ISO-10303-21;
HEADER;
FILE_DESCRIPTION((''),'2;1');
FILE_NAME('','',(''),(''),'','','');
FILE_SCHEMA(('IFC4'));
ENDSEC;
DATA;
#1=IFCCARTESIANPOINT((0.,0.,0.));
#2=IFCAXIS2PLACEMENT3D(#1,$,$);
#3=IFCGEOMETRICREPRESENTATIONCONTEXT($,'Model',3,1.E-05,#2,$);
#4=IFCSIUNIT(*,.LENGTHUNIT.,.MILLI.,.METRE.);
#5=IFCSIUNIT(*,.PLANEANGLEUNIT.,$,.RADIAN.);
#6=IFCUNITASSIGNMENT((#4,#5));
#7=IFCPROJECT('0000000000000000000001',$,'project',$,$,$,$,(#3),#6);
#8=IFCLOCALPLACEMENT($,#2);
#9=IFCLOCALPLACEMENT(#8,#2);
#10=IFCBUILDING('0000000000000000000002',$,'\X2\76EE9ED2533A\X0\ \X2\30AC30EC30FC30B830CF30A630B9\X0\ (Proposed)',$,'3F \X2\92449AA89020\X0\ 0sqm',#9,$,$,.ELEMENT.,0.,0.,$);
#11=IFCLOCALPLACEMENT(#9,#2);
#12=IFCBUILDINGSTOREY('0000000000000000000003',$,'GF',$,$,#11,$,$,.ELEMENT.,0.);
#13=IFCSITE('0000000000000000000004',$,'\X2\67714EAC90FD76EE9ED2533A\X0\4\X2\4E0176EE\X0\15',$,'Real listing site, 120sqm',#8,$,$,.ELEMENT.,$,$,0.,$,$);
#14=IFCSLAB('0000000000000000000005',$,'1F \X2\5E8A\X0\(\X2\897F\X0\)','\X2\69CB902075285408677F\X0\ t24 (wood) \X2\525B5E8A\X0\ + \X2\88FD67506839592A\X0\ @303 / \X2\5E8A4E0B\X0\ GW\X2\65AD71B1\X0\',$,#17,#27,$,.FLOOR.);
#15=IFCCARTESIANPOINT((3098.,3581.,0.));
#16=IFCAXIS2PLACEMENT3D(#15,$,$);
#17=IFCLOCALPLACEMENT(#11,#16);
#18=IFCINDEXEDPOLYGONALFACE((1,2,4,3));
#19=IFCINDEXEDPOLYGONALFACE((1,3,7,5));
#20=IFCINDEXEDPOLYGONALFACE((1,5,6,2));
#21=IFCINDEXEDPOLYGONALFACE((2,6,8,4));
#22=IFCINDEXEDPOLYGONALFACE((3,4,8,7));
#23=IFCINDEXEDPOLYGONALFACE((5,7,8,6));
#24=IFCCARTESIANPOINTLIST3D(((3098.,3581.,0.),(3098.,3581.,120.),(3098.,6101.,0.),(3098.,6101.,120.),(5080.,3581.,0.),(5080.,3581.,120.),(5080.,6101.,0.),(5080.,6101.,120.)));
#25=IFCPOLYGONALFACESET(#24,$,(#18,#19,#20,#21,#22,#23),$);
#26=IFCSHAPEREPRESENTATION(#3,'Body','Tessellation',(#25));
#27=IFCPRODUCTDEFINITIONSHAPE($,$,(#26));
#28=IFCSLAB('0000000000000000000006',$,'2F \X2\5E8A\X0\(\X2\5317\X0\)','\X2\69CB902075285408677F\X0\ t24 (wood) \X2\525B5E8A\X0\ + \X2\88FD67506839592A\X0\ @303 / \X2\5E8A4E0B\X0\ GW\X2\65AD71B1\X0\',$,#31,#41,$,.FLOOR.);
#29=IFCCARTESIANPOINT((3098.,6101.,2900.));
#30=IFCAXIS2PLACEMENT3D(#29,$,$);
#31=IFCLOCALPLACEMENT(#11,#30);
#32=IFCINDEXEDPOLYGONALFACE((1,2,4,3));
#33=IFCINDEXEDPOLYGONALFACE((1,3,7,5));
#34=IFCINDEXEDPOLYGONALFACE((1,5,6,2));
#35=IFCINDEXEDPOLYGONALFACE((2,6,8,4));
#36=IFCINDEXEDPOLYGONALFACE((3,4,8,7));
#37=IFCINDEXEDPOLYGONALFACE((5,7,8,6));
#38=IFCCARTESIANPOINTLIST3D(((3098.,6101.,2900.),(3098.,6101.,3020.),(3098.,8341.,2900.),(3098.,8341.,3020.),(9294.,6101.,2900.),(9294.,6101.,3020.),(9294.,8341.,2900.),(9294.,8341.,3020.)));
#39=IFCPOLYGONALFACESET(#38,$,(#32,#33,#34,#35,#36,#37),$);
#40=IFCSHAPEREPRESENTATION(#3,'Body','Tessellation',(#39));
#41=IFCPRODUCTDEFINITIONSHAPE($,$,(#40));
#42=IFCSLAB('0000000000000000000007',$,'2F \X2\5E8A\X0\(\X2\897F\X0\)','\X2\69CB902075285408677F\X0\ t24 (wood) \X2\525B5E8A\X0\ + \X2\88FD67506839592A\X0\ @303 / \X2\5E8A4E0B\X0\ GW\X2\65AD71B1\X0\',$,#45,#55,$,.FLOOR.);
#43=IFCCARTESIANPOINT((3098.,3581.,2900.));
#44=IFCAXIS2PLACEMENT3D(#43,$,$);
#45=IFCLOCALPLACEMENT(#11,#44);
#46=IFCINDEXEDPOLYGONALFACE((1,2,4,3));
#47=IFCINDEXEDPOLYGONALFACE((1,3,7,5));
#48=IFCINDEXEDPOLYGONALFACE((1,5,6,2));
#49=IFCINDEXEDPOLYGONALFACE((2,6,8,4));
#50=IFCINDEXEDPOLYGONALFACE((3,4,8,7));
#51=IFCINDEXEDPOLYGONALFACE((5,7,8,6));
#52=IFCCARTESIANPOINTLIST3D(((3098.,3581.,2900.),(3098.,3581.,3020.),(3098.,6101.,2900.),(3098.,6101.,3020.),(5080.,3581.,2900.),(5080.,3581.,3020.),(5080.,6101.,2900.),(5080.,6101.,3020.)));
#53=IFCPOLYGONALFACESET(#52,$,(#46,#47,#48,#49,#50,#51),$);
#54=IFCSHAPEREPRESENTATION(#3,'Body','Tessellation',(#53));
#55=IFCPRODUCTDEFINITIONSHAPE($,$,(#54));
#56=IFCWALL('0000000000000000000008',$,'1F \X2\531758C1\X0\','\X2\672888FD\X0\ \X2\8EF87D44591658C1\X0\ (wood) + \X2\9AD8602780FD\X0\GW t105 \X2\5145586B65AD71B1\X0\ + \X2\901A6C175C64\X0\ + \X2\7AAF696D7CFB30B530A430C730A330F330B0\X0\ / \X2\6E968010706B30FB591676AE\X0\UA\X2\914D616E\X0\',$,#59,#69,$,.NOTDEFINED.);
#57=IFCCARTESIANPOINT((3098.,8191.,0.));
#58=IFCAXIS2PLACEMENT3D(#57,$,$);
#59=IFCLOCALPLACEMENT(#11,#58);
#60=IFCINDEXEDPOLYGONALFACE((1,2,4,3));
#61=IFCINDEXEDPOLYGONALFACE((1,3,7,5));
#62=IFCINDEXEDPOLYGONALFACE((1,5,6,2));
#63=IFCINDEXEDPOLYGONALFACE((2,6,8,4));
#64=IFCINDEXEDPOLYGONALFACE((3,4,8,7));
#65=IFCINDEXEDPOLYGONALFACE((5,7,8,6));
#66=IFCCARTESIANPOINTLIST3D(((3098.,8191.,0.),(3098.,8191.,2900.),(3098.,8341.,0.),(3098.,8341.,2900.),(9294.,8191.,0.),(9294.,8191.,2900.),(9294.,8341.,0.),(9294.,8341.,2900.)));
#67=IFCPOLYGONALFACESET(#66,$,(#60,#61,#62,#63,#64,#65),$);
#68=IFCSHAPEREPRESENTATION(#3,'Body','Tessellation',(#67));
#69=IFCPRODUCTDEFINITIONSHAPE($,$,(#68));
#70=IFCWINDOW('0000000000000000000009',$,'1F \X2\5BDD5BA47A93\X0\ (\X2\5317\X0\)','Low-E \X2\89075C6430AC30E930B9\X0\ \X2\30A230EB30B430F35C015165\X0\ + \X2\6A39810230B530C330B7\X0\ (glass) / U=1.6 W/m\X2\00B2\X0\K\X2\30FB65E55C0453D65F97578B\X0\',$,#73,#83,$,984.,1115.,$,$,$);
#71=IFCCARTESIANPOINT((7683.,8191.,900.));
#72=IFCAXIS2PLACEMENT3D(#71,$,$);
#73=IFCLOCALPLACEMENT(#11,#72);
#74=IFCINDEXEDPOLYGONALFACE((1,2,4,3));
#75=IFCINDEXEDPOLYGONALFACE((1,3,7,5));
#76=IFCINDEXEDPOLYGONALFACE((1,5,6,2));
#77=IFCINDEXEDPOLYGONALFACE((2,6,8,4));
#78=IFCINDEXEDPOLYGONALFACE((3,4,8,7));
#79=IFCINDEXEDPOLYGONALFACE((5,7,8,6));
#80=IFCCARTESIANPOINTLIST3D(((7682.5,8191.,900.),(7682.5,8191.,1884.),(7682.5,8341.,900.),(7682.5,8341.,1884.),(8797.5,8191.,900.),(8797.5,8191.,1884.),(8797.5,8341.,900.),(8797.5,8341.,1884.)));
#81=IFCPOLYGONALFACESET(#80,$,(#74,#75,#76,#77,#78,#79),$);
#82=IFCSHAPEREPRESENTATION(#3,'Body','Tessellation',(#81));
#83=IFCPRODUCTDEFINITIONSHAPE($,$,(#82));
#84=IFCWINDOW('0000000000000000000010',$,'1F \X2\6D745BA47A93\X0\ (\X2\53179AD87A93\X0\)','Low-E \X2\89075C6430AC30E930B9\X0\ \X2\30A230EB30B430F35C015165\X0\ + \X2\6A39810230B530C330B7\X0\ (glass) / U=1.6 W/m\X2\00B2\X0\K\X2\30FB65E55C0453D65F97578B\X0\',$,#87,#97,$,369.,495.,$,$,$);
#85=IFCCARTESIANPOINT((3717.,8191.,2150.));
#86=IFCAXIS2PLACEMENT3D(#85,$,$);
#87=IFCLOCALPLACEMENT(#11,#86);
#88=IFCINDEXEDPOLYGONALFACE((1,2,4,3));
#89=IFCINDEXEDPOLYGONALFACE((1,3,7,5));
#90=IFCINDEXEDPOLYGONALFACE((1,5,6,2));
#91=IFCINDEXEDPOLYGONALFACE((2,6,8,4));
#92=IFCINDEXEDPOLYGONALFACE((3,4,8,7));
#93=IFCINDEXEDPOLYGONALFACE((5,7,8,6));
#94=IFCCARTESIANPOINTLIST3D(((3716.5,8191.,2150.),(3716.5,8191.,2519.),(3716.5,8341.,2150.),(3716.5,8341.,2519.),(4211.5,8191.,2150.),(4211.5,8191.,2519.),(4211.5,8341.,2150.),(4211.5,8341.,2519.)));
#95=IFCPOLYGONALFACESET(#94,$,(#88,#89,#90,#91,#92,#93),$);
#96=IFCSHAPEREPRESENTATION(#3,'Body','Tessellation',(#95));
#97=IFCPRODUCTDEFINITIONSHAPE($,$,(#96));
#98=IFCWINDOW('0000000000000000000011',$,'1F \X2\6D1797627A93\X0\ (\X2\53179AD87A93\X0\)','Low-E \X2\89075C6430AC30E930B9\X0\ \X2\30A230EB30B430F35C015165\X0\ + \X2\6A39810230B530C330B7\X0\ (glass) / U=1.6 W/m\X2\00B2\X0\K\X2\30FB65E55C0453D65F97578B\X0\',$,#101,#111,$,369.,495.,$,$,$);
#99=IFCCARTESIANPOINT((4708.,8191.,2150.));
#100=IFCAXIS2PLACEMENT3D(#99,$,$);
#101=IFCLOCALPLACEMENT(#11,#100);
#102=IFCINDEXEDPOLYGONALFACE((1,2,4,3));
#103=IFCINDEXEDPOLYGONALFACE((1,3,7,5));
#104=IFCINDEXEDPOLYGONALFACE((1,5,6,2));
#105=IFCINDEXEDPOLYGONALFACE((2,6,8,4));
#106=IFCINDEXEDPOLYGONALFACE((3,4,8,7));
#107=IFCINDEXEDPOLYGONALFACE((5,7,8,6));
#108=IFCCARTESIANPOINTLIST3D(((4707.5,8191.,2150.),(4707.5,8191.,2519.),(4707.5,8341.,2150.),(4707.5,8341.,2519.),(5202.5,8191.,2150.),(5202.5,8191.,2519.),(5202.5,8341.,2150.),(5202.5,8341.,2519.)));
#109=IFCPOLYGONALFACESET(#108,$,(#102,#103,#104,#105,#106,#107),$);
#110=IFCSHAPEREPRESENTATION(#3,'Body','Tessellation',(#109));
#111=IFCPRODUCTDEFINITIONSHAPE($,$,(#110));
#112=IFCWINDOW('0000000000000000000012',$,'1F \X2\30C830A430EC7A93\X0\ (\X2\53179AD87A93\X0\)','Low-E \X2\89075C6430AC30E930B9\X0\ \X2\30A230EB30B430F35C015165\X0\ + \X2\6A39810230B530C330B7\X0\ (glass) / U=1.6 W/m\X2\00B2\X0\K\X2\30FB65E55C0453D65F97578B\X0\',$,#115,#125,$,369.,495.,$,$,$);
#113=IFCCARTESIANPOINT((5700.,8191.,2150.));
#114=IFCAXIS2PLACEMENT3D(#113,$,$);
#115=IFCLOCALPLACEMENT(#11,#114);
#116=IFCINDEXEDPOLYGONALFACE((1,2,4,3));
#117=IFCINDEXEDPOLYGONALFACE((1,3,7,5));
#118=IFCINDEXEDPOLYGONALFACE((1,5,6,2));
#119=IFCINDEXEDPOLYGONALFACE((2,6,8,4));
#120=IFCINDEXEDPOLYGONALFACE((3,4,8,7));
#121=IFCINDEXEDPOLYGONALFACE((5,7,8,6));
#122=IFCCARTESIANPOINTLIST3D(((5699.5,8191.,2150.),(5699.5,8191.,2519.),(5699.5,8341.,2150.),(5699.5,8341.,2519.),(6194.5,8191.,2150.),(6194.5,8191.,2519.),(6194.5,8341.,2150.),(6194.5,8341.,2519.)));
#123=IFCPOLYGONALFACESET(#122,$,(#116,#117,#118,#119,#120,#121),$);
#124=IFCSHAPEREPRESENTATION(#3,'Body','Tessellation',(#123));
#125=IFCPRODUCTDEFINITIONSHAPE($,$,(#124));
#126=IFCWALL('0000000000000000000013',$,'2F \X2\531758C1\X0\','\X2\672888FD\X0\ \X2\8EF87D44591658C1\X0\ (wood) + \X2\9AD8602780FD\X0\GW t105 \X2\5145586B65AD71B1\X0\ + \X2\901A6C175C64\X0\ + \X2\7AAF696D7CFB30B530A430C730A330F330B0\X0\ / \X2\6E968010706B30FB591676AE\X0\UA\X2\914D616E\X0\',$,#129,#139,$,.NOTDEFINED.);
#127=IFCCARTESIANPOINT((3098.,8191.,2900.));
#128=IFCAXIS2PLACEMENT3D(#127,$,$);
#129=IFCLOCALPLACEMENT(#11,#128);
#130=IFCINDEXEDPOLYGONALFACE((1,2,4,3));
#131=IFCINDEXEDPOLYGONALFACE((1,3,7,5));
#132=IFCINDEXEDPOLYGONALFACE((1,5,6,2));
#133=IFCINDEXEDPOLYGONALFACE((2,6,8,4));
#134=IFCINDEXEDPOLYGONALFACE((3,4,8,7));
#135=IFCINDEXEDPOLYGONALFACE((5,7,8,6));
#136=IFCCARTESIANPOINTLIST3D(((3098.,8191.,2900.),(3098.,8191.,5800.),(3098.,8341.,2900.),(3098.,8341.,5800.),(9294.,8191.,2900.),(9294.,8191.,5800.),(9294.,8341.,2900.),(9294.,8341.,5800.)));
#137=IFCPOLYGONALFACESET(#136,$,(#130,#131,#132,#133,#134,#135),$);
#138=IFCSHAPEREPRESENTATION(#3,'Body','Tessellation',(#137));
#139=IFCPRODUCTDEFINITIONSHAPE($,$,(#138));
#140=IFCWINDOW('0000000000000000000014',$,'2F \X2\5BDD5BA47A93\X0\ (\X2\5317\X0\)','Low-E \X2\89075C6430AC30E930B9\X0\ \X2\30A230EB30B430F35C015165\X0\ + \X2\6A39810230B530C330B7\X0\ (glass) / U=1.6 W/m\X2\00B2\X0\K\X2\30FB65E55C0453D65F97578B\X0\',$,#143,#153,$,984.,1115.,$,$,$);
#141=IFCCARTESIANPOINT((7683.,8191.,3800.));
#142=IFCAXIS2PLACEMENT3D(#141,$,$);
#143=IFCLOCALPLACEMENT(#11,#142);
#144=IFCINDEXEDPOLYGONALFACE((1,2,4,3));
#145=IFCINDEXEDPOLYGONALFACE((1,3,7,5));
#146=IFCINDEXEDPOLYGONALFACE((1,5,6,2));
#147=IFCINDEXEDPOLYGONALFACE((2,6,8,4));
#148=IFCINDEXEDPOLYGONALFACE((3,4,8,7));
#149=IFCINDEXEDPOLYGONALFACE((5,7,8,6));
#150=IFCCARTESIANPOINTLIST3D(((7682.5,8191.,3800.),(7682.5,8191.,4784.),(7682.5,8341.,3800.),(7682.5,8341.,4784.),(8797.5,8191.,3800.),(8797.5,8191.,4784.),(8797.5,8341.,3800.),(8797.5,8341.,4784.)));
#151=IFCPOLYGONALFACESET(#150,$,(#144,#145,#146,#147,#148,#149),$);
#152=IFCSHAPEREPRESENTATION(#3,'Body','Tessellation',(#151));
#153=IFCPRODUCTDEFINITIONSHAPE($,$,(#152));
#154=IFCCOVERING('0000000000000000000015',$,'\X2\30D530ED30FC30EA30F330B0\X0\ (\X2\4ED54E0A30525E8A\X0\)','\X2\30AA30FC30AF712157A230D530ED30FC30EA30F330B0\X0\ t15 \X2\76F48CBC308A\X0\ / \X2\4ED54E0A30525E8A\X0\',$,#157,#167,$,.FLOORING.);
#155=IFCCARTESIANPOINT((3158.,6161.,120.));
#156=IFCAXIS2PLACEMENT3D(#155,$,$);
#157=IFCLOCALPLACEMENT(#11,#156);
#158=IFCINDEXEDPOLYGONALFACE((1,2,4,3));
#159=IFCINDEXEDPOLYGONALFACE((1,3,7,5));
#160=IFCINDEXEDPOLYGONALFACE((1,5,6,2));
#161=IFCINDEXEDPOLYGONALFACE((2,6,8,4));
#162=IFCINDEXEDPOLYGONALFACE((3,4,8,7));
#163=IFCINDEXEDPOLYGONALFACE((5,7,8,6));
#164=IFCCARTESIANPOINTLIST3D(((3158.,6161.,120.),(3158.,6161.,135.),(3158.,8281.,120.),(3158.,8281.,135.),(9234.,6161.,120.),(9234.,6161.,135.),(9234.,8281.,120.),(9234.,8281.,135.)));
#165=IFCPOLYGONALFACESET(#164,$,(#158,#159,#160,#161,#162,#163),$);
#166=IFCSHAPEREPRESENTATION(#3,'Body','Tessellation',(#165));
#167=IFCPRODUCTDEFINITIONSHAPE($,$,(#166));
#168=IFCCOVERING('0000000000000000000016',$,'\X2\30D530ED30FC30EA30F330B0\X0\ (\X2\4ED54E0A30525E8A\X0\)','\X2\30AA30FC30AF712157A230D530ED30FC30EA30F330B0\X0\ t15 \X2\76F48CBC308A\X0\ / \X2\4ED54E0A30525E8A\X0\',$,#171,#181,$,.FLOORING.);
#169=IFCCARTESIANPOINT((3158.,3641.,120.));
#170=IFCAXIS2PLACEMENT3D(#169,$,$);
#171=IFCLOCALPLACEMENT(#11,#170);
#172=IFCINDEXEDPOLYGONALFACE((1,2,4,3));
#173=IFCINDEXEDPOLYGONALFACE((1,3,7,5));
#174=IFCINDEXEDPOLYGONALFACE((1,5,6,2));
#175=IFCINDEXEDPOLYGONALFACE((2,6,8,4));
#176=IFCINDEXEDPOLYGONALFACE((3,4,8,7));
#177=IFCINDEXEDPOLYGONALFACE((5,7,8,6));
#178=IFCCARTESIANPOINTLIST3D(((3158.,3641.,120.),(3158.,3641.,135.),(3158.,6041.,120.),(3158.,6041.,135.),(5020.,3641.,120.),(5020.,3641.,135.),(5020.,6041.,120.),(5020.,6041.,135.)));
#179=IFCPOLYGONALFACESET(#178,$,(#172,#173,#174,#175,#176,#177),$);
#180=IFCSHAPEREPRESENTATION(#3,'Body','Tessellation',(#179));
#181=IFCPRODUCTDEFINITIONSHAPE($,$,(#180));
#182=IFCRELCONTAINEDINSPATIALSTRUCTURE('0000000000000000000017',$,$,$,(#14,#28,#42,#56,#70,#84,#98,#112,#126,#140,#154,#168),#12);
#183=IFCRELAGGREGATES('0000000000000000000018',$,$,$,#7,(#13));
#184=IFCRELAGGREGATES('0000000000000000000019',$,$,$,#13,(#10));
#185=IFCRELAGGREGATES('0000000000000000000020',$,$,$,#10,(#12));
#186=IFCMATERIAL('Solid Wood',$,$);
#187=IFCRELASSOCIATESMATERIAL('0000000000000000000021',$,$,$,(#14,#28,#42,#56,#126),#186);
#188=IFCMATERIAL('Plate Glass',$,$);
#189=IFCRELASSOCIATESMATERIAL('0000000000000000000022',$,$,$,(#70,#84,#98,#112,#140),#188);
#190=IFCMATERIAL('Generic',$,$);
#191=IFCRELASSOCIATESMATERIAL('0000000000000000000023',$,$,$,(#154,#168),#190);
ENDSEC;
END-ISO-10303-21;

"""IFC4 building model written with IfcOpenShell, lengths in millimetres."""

from ifc_helpers import new_model, si_unit, frame, frame_2d, origin, place, context, project, spatial, rectangle, extrude, material, element, fill, save


model = new_model("IFC4")

# Units and contexts
model_context = context("Model", 3, precision=1e-05, world=origin())
ifc_project = project(units=[si_unit("LENGTHUNIT", "METRE", prefix="MILLI"), si_unit("PLANEANGLEUNIT", "RADIAN")], contexts=[model_context])

# Site, building, storey
site_placement = place(None, origin())
site = spatial("IfcSite", under=ifc_project, at=site_placement, Name="東京都目黒区4丁目15", ObjectType="Real listing site, 120sqm", CompositionType="ELEMENT", RefElevation=0.0)
building_placement = place(site_placement, origin())
building = spatial("IfcBuilding", under=site, at=building_placement, Name="目黒区 ガレージハウス (Proposed)", ObjectType="3F 鉄骨造 0sqm", CompositionType="ELEMENT", ElevationOfRefHeight=0.0, ElevationOfTerrain=0.0)
storey_placement = place(building_placement, origin())
storey = spatial("IfcBuildingStorey", under=building, at=storey_placement, Name="GF", CompositionType="ELEMENT", Elevation=0.0)

# Slabs
ifc_material_1 = material(Name="Solid Wood")
slab_1_placement = place(storey_placement, frame((3098.0, 3581.0, 0.0)))
element("IfcSlab", 1, at=slab_1_placement, inside=storey, material=ifc_material_1, Name="1F 床(西)", Description="構造用合板 t24 (wood) 剛床 + 製材根太 @303 / 床下 GW断熱", PredefinedType="FLOOR", context=model_context, shape_type="SweptSolid", body=[
    extrude(rectangle(XDim=1982.0, YDim=2520.0, at=frame_2d((991.0, 1260.0))), frame((3098.0, 3581.0, 0.0)), (0.0, 0.0, 1.0), 120.0),
])
slab_2_placement = place(storey_placement, frame((3098.0, 6101.0, 2900.0)))
element("IfcSlab", 2, at=slab_2_placement, inside=storey, material=ifc_material_1, Name="2F 床(北)", Description="構造用合板 t24 (wood) 剛床 + 製材根太 @303 / 床下 GW断熱", PredefinedType="FLOOR", context=model_context, shape_type="SweptSolid", body=[
    extrude(rectangle(XDim=6196.0, YDim=2240.0, at=frame_2d((3098.0, 1120.0))), frame((3098.0, 6101.0, 2900.0)), (0.0, 0.0, 1.0), 120.0),
])
slab_3_placement = place(storey_placement, frame((3098.0, 3581.0, 2900.0)))
element("IfcSlab", 3, at=slab_3_placement, inside=storey, material=ifc_material_1, Name="2F 床(西)", Description="構造用合板 t24 (wood) 剛床 + 製材根太 @303 / 床下 GW断熱", PredefinedType="FLOOR", context=model_context, shape_type="SweptSolid", body=[
    extrude(rectangle(XDim=1982.0, YDim=2520.0, at=frame_2d((991.0, 1260.0))), frame((3098.0, 3581.0, 2900.0)), (0.0, 0.0, 1.0), 120.0),
])

# Wall, openings, windows
wall_1_placement = place(storey_placement, frame((3098.0, 8191.0, 0.0)))
wall_1 = element("IfcWall", 4, at=wall_1_placement, inside=storey, material=ifc_material_1, Name="1F 北壁", Description="木製 軸組外壁 (wood) + 高性能GW t105 充填断熱 + 通気層 + 窯業系サイディング / 準耐火・外皮UA配慮", PredefinedType="NOTDEFINED", context=model_context, shape_type="SweptSolid", body=[
    extrude(rectangle(XDim=6196.0, YDim=150.0, at=frame_2d((3098.0, 75.0))), frame((3098.0, 8191.0, 0.0)), (0.0, 0.0, 1.0), 2900.0),
])
opening_1_placement = place(storey_placement, frame((7683.0, 8191.0, 900.0)))
opening_1 = element("IfcOpeningElement", 5, at=opening_1_placement, cuts=wall_1, PredefinedType="NOTDEFINED", context=model_context, shape_type="SweptSolid", body=[
    extrude(rectangle(XDim=1115.0, YDim=150.0, at=frame_2d((557.0, 75.0))), frame((7683.0, 8191.0, 900.0)), (0.0, 0.0, 1.0), 984.0),
])
opening_2_placement = place(storey_placement, frame((3717.0, 8191.0, 2150.0)))
opening_2 = element("IfcOpeningElement", 6, at=opening_2_placement, cuts=wall_1, PredefinedType="NOTDEFINED", context=model_context, shape_type="SweptSolid", body=[
    extrude(rectangle(XDim=495.0, YDim=150.0, at=frame_2d((247.0, 75.0))), frame((3717.0, 8191.0, 2150.0)), (0.0, 0.0, 1.0), 369.0),
])
opening_3_placement = place(storey_placement, frame((4708.0, 8191.0, 2150.0)))
opening_3 = element("IfcOpeningElement", 7, at=opening_3_placement, cuts=wall_1, PredefinedType="NOTDEFINED", context=model_context, shape_type="SweptSolid", body=[
    extrude(rectangle(XDim=495.0, YDim=150.0, at=frame_2d((247.0, 75.0))), frame((4708.0, 8191.0, 2150.0)), (0.0, 0.0, 1.0), 369.0),
])
opening_4_placement = place(storey_placement, frame((5700.0, 8191.0, 2150.0)))
opening_4 = element("IfcOpeningElement", 8, at=opening_4_placement, cuts=wall_1, PredefinedType="NOTDEFINED", context=model_context, shape_type="SweptSolid", body=[
    extrude(rectangle(XDim=495.0, YDim=150.0, at=frame_2d((247.0, 75.0))), frame((5700.0, 8191.0, 2150.0)), (0.0, 0.0, 1.0), 369.0),
])
ifc_material_2 = material(Name="Plate Glass")
window_1_placement = place(storey_placement, frame((7683.0, 8191.0, 900.0)))
window_1 = element("IfcWindow", 9, at=window_1_placement, inside=storey, material=ifc_material_2, Name="1F 寝室窓 (北)", Description="Low-E 複層ガラス アルゴン封入 + 樹脂サッシ (glass) / U=1.6 W/m²K・日射取得型", OverallHeight=984.0, OverallWidth=1115.0, context=model_context, shape_type="SweptSolid", body=[
    extrude(rectangle(XDim=1115.0, YDim=150.0, at=frame_2d((557.0, 75.0))), frame((7683.0, 8191.0, 900.0)), (0.0, 0.0, 1.0), 984.0),
])
fill(opening_1, window_1)
window_2_placement = place(storey_placement, frame((3717.0, 8191.0, 2150.0)))
window_2 = element("IfcWindow", 10, at=window_2_placement, inside=storey, material=ifc_material_2, Name="1F 浴室窓 (北高窓)", Description="Low-E 複層ガラス アルゴン封入 + 樹脂サッシ (glass) / U=1.6 W/m²K・日射取得型", OverallHeight=369.0, OverallWidth=495.0, context=model_context, shape_type="SweptSolid", body=[
    extrude(rectangle(XDim=495.0, YDim=150.0, at=frame_2d((247.0, 75.0))), frame((3717.0, 8191.0, 2150.0)), (0.0, 0.0, 1.0), 369.0),
])
fill(opening_2, window_2)
window_3_placement = place(storey_placement, frame((4708.0, 8191.0, 2150.0)))
window_3 = element("IfcWindow", 11, at=window_3_placement, inside=storey, material=ifc_material_2, Name="1F 洗面窓 (北高窓)", Description="Low-E 複層ガラス アルゴン封入 + 樹脂サッシ (glass) / U=1.6 W/m²K・日射取得型", OverallHeight=369.0, OverallWidth=495.0, context=model_context, shape_type="SweptSolid", body=[
    extrude(rectangle(XDim=495.0, YDim=150.0, at=frame_2d((247.0, 75.0))), frame((4708.0, 8191.0, 2150.0)), (0.0, 0.0, 1.0), 369.0),
])
fill(opening_3, window_3)
window_4_placement = place(storey_placement, frame((5700.0, 8191.0, 2150.0)))
window_4 = element("IfcWindow", 12, at=window_4_placement, inside=storey, material=ifc_material_2, Name="1F トイレ窓 (北高窓)", Description="Low-E 複層ガラス アルゴン封入 + 樹脂サッシ (glass) / U=1.6 W/m²K・日射取得型", OverallHeight=369.0, OverallWidth=495.0, context=model_context, shape_type="SweptSolid", body=[
    extrude(rectangle(XDim=495.0, YDim=150.0, at=frame_2d((247.0, 75.0))), frame((5700.0, 8191.0, 2150.0)), (0.0, 0.0, 1.0), 369.0),
])
fill(opening_4, window_4)

# Wall, opening, window
wall_2_placement = place(storey_placement, frame((3098.0, 8191.0, 2900.0)))
wall_2 = element("IfcWall", 13, at=wall_2_placement, inside=storey, material=ifc_material_1, Name="2F 北壁", Description="木製 軸組外壁 (wood) + 高性能GW t105 充填断熱 + 通気層 + 窯業系サイディング / 準耐火・外皮UA配慮", PredefinedType="NOTDEFINED", context=model_context, shape_type="SweptSolid", body=[
    extrude(rectangle(XDim=6196.0, YDim=150.0, at=frame_2d((3098.0, 75.0))), frame((3098.0, 8191.0, 2900.0)), (0.0, 0.0, 1.0), 2900.0),
])
opening_5_placement = place(storey_placement, frame((7683.0, 8191.0, 3800.0)))
opening_5 = element("IfcOpeningElement", 14, at=opening_5_placement, cuts=wall_2, PredefinedType="NOTDEFINED", context=model_context, shape_type="SweptSolid", body=[
    extrude(rectangle(XDim=1115.0, YDim=150.0, at=frame_2d((557.0, 75.0))), frame((7683.0, 8191.0, 3800.0)), (0.0, 0.0, 1.0), 984.0),
])
window_5_placement = place(storey_placement, frame((7683.0, 8191.0, 3800.0)))
window_5 = element("IfcWindow", 15, at=window_5_placement, inside=storey, material=ifc_material_2, Name="2F 寝室窓 (北)", Description="Low-E 複層ガラス アルゴン封入 + 樹脂サッシ (glass) / U=1.6 W/m²K・日射取得型", OverallHeight=984.0, OverallWidth=1115.0, context=model_context, shape_type="SweptSolid", body=[
    extrude(rectangle(XDim=1115.0, YDim=150.0, at=frame_2d((557.0, 75.0))), frame((7683.0, 8191.0, 3800.0)), (0.0, 0.0, 1.0), 984.0),
])
fill(opening_5, window_5)

# Coverings
ifc_material_3 = material(Name="Generic")
covering_1_placement = place(storey_placement, frame((3158.0, 6161.0, 120.0)))
element("IfcCovering", 16, at=covering_1_placement, inside=storey, material=ifc_material_3, Name="フローリング (仕上げ床)", Description="オーク無垢フローリング t15 直貼り / 仕上げ床", PredefinedType="FLOORING", context=model_context, shape_type="SweptSolid", body=[
    extrude(rectangle(XDim=6076.0, YDim=2120.0, at=frame_2d((3038.0, 1060.0))), frame((3158.0, 6161.0, 120.0)), (0.0, 0.0, 1.0), 15.0),
])
covering_2_placement = place(storey_placement, frame((3158.0, 3641.0, 120.0)))
element("IfcCovering", 17, at=covering_2_placement, inside=storey, material=ifc_material_3, Name="フローリング (仕上げ床)", Description="オーク無垢フローリング t15 直貼り / 仕上げ床", PredefinedType="FLOORING", context=model_context, shape_type="SweptSolid", body=[
    extrude(rectangle(XDim=1862.0, YDim=2400.0, at=frame_2d((931.0, 1200.0))), frame((3158.0, 3641.0, 120.0)), (0.0, 0.0, 1.0), 15.0),
])

save(model, "model.ifc")
